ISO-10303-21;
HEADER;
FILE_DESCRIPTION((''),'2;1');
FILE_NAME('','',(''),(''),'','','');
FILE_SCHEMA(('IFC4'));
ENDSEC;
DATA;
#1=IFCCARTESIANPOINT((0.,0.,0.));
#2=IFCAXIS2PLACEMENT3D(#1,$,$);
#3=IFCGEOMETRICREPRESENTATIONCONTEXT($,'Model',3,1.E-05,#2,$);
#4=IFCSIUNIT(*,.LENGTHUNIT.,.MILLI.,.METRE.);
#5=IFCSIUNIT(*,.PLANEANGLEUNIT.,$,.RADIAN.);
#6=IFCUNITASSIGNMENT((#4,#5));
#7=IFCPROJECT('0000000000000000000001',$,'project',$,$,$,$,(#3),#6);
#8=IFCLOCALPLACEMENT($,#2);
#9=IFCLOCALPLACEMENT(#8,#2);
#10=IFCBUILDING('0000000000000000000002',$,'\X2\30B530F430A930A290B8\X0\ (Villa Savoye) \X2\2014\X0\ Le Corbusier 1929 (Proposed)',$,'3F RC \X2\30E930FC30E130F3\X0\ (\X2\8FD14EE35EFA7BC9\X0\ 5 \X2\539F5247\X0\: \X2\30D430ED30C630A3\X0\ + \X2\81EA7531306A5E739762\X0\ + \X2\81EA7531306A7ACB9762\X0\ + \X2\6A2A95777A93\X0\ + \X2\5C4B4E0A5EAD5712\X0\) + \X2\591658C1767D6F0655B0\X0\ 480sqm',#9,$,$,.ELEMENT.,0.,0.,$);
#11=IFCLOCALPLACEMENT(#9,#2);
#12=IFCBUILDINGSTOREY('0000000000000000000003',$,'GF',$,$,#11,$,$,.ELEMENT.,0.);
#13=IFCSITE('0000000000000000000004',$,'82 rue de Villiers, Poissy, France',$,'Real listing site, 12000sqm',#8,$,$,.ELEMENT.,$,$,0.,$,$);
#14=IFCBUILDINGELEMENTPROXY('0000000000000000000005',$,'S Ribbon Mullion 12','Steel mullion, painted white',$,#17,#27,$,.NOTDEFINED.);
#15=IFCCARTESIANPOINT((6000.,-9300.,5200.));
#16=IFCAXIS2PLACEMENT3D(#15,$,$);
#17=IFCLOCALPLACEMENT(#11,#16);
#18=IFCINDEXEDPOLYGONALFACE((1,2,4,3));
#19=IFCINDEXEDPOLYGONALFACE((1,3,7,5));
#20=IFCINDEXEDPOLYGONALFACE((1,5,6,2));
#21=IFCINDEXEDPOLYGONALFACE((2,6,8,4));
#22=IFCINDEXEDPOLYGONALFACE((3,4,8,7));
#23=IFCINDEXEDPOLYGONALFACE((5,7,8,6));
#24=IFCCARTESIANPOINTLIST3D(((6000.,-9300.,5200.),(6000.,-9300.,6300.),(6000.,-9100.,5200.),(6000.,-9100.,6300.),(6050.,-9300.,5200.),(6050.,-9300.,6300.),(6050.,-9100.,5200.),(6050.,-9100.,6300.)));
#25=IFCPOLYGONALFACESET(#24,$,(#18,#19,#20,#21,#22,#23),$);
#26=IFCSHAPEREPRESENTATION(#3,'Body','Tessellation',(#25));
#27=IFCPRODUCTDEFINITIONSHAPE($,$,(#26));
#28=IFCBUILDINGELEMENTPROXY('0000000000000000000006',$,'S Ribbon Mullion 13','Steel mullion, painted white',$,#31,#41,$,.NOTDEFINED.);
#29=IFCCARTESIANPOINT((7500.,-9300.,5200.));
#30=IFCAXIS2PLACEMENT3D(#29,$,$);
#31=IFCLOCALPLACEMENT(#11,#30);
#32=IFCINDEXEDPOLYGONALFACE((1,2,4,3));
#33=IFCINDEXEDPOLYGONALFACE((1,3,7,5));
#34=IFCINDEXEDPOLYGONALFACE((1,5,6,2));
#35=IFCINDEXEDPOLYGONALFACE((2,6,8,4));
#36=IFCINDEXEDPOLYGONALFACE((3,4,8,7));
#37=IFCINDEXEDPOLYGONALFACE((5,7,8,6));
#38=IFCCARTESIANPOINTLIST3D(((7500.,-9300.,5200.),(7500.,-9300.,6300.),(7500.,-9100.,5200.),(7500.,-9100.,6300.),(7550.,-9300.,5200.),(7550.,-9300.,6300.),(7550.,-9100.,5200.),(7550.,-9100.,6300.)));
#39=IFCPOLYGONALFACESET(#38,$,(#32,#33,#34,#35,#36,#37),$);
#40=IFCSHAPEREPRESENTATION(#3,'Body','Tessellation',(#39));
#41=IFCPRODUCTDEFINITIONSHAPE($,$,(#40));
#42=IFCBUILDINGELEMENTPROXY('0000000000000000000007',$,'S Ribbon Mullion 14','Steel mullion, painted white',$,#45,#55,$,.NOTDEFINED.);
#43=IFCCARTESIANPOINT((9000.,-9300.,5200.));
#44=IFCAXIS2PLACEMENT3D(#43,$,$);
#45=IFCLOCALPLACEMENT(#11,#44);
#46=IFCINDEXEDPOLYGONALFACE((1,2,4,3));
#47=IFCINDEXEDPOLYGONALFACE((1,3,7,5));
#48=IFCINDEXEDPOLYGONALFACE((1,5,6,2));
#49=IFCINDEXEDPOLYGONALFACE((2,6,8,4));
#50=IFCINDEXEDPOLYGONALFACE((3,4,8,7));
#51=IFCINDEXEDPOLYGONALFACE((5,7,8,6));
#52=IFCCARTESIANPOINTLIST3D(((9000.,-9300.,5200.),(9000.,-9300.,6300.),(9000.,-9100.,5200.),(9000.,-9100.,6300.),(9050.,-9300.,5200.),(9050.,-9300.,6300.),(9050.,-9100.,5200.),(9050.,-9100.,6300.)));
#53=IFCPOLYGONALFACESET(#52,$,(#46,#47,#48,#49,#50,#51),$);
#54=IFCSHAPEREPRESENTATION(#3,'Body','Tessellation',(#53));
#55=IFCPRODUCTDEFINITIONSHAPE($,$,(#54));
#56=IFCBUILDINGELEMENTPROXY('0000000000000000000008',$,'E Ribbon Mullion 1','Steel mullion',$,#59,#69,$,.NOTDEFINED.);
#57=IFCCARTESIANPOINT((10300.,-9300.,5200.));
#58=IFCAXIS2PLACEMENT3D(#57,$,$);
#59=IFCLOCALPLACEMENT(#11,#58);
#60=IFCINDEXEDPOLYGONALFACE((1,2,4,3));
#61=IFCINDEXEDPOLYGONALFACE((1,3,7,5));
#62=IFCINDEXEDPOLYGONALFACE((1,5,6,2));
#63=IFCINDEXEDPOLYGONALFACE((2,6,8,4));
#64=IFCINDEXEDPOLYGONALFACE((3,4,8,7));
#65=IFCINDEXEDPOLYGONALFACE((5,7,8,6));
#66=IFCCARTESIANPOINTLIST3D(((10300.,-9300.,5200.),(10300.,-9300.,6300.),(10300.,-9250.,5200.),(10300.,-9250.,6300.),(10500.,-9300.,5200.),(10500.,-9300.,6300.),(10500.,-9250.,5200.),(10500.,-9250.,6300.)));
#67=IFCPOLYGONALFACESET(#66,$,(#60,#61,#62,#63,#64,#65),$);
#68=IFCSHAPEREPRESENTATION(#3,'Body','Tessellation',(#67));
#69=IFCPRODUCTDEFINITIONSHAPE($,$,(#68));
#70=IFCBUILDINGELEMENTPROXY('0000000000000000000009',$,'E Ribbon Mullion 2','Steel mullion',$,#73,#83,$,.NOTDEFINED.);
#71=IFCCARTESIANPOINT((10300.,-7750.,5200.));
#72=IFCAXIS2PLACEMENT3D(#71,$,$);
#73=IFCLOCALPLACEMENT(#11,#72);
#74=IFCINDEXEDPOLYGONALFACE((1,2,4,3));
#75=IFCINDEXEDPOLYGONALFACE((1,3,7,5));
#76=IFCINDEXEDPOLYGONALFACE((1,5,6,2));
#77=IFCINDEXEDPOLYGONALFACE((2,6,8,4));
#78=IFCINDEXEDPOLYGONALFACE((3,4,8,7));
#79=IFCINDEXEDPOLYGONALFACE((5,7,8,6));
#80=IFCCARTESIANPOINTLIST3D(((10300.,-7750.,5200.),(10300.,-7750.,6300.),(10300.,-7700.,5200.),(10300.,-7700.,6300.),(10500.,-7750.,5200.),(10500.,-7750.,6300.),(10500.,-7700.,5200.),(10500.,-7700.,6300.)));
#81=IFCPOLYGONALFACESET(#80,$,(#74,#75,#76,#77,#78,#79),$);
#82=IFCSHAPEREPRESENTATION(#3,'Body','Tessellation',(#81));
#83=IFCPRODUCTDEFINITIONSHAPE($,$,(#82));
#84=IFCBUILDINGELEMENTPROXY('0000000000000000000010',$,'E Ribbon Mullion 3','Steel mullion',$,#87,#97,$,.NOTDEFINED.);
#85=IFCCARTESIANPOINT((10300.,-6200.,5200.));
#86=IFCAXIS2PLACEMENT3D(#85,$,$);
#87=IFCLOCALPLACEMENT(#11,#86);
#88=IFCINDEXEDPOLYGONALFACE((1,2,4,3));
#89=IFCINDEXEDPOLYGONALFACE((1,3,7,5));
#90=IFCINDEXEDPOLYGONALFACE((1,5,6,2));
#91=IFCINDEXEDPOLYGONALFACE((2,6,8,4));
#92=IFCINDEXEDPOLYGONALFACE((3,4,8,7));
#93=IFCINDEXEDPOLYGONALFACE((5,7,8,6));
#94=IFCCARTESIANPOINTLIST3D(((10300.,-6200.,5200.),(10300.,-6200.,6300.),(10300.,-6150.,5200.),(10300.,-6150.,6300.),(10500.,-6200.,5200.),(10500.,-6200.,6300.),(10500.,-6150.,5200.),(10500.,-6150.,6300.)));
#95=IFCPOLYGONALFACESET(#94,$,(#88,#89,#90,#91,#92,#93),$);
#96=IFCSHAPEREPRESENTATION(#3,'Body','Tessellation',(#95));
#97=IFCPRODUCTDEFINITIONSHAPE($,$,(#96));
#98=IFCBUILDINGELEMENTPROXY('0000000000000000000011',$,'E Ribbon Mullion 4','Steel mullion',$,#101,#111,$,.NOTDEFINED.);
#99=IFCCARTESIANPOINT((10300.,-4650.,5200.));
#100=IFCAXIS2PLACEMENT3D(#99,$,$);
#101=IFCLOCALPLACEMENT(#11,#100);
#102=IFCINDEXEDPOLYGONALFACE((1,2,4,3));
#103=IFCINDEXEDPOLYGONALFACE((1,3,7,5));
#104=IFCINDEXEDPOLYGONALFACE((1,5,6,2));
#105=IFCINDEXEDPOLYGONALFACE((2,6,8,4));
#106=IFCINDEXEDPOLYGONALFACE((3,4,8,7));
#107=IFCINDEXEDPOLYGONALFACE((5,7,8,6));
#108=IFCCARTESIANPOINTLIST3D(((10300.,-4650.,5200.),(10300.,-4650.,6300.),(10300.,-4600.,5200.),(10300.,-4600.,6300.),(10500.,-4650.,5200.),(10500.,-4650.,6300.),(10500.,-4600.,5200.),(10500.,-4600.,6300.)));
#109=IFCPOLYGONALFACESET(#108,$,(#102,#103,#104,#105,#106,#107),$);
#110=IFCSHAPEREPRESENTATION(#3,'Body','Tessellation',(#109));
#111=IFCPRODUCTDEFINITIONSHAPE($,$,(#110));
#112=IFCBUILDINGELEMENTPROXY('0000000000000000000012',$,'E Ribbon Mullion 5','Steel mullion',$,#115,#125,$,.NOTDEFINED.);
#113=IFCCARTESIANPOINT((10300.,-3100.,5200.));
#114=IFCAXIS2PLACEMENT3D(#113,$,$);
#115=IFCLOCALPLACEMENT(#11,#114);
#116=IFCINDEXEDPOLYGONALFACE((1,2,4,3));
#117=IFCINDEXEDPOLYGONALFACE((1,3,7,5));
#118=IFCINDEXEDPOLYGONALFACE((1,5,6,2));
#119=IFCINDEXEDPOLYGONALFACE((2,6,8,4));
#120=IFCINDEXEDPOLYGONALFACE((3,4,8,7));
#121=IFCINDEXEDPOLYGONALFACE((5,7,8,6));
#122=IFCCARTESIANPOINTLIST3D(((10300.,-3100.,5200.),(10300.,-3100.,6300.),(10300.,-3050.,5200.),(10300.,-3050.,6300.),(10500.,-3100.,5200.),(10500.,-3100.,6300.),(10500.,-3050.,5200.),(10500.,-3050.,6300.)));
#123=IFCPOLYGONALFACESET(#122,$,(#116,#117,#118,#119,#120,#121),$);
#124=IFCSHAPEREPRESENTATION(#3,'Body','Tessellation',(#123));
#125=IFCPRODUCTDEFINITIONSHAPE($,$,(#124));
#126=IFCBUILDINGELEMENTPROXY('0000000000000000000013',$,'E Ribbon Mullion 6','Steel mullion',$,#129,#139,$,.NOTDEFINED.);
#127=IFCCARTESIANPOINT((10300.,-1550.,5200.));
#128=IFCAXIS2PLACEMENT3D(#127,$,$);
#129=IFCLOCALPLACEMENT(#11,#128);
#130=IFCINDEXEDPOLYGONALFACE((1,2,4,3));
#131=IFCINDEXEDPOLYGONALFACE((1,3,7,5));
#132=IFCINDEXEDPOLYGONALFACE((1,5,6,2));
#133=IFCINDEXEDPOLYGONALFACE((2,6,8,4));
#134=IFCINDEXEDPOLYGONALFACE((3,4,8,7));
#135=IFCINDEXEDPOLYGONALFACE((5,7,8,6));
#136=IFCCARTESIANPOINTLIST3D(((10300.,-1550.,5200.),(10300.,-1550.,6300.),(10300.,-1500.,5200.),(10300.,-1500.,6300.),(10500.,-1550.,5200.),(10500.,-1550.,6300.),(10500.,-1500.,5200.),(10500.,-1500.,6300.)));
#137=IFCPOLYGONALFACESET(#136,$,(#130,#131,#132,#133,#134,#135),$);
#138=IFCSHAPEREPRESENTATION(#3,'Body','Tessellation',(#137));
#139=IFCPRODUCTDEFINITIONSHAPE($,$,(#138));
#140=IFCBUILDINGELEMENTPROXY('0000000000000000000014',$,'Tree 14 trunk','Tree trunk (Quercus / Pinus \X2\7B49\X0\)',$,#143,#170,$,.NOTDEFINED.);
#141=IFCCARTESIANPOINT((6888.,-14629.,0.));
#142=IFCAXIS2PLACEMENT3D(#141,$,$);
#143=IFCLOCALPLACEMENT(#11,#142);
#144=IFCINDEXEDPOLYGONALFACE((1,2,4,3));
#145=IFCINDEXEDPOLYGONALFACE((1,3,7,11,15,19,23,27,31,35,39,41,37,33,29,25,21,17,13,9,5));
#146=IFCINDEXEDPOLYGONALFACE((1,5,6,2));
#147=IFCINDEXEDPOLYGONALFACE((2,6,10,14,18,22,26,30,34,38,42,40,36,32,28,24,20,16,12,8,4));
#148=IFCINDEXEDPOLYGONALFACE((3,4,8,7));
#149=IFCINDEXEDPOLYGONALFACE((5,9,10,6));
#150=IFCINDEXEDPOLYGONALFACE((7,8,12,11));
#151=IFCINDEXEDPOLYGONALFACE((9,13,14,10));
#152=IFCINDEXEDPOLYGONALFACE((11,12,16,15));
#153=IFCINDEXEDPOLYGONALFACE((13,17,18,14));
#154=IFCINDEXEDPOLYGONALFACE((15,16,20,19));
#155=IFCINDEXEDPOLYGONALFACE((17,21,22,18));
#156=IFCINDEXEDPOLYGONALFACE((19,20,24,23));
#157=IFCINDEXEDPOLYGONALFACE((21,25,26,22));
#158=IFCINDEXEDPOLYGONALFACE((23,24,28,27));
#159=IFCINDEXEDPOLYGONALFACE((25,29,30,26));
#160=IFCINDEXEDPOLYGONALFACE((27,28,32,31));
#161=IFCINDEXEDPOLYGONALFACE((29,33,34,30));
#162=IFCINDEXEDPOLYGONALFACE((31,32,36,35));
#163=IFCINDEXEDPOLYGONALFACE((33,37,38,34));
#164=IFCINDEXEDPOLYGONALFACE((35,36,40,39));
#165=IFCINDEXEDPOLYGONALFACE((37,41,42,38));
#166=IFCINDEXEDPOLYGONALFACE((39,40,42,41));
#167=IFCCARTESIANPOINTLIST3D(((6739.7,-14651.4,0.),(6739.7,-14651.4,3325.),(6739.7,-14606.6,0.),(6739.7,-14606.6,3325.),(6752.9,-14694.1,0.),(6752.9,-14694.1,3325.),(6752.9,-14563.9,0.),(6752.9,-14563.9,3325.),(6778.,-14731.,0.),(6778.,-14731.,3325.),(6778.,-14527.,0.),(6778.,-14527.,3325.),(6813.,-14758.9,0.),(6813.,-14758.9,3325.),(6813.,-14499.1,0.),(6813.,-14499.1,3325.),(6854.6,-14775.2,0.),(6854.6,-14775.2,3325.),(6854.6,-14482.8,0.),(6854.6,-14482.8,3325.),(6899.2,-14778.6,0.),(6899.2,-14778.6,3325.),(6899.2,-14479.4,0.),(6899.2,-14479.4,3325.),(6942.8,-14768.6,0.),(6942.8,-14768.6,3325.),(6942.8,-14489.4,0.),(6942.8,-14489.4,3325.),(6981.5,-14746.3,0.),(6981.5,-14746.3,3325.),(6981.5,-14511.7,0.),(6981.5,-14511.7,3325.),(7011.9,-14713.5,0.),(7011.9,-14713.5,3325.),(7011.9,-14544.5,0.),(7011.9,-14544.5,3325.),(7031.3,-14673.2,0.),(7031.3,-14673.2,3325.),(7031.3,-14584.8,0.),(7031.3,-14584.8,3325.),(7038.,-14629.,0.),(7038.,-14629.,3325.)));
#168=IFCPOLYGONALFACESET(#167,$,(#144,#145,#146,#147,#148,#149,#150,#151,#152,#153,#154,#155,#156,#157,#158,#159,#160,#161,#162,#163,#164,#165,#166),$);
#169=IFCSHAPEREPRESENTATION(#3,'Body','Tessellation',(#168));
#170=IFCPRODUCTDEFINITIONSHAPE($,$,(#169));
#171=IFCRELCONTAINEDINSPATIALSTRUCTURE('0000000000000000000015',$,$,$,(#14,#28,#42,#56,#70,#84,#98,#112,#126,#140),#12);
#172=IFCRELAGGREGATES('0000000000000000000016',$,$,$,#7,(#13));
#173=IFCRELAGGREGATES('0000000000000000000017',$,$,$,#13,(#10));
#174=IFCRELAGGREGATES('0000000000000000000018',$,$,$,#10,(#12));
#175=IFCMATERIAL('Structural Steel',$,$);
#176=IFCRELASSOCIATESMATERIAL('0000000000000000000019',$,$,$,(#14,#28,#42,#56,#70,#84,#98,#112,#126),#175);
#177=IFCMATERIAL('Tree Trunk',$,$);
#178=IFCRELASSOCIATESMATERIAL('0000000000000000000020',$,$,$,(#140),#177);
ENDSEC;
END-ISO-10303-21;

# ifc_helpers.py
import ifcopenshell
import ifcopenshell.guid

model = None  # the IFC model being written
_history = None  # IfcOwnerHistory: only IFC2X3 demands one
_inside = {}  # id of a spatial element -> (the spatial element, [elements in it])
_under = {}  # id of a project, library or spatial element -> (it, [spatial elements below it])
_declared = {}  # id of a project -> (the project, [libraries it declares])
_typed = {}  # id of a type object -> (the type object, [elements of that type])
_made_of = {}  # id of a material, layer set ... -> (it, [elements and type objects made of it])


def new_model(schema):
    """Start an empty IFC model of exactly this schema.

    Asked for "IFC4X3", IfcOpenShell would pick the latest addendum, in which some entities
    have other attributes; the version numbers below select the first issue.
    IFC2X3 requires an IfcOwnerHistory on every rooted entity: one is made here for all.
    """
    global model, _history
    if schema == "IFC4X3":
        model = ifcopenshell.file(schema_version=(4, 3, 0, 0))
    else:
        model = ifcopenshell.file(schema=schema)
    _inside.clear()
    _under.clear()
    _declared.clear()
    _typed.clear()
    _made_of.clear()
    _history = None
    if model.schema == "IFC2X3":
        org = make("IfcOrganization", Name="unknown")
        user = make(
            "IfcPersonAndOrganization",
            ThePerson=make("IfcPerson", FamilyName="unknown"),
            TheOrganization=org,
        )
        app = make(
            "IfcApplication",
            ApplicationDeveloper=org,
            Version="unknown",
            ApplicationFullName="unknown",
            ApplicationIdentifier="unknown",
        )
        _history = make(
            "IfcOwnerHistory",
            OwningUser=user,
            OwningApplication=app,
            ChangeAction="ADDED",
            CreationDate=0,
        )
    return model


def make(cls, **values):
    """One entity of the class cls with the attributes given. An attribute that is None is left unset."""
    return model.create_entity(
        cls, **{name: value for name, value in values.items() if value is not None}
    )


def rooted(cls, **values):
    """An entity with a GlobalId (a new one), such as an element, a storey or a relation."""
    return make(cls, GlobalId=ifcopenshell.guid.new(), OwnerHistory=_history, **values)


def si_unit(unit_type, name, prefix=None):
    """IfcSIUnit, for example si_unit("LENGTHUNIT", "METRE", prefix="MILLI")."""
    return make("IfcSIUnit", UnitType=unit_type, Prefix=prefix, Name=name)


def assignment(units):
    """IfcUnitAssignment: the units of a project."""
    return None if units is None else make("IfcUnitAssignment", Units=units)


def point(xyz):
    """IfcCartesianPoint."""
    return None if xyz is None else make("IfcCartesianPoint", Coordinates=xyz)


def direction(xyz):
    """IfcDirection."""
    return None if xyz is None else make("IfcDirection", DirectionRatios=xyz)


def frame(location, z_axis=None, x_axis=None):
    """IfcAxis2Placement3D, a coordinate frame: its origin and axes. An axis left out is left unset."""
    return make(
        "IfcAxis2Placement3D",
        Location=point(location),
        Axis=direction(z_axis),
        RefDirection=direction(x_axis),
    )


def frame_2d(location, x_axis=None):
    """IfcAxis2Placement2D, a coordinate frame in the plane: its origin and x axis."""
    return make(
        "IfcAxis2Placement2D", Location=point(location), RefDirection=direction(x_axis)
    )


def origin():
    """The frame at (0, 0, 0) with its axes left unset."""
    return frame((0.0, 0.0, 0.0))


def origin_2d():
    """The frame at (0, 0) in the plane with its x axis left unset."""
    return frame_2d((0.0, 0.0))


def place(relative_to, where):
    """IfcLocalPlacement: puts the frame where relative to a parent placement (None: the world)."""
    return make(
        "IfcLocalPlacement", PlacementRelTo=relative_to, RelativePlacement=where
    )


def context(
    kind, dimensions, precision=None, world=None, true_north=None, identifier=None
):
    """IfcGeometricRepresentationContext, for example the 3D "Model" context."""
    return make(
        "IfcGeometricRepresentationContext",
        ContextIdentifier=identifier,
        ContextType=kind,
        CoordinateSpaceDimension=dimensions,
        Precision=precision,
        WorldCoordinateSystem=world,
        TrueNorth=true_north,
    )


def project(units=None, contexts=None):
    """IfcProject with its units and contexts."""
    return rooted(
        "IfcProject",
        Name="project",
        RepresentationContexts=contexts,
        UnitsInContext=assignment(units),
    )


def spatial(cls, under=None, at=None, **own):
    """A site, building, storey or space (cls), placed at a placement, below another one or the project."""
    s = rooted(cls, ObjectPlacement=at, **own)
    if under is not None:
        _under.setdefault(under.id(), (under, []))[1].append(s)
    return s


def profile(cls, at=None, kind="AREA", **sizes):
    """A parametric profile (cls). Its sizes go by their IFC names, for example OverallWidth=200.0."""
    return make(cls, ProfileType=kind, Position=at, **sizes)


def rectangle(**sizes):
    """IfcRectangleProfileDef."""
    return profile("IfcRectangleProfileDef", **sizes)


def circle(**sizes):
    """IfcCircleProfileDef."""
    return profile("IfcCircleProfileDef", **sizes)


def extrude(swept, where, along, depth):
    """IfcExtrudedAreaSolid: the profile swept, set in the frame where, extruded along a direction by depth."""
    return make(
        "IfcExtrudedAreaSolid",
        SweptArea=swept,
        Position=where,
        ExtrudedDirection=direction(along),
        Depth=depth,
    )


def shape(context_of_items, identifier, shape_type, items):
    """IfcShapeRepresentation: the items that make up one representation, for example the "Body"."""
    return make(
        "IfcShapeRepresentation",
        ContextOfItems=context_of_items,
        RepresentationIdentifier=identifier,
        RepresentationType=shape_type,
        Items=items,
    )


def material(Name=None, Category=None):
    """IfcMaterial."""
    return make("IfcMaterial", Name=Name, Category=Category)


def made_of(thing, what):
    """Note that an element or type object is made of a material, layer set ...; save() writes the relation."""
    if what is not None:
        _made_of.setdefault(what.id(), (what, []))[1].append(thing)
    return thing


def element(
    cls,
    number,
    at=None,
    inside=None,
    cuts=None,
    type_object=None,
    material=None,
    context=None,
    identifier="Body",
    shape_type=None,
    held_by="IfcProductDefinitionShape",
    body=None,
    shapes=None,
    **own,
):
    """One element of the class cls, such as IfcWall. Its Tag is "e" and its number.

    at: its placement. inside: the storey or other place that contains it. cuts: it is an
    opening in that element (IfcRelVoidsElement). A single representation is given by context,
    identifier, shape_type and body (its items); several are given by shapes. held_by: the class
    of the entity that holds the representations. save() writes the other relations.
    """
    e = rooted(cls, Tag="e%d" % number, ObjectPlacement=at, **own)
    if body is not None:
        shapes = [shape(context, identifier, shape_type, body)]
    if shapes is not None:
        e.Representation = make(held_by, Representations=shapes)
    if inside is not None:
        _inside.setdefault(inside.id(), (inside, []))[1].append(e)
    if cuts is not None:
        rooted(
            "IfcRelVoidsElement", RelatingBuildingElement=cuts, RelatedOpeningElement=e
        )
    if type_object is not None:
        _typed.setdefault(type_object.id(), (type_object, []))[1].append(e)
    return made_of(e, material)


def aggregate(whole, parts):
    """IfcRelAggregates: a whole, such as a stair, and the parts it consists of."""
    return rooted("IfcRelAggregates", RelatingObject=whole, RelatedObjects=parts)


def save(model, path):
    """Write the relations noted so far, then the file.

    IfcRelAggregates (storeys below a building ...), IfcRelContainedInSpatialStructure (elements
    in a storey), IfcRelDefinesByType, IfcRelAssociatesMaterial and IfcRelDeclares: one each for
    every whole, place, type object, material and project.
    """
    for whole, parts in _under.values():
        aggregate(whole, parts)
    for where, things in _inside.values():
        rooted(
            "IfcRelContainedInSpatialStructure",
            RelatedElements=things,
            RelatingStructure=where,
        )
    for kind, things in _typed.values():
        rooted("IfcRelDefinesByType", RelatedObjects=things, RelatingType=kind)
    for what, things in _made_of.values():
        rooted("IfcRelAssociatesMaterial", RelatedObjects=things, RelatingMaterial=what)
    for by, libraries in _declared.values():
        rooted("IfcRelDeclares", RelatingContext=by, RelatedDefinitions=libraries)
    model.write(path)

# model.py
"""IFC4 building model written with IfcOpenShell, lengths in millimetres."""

from ifc_helpers import new_model, si_unit, frame, frame_2d, origin, origin_2d, place, context, project, spatial, rectangle, circle, extrude, material, element, save


model = new_model("IFC4")

# Units and contexts
model_context = context("Model", 3, precision=1e-05, world=origin())
ifc_project = project(units=[si_unit("LENGTHUNIT", "METRE", prefix="MILLI"), si_unit("PLANEANGLEUNIT", "RADIAN")], contexts=[model_context])

# Site, building, storey
site_placement = place(None, origin())
site = spatial("IfcSite", under=ifc_project, at=site_placement, Name="82 rue de Villiers, Poissy, France", ObjectType="Real listing site, 12000sqm", CompositionType="ELEMENT", RefElevation=0.0)
building_placement = place(site_placement, origin())
building = spatial("IfcBuilding", under=site, at=building_placement, Name="サヴォア邸 (Villa Savoye) — Le Corbusier 1929 (Proposed)", ObjectType="3F RC ラーメン (近代建築 5 原則: ピロティ + 自由な平面 + 自由な立面 + 横長窓 + 屋上庭園) + 外壁白漆喰 480sqm", CompositionType="ELEMENT", ElevationOfRefHeight=0.0, ElevationOfTerrain=0.0)
storey_placement = place(building_placement, origin())
storey = spatial("IfcBuildingStorey", under=building, at=storey_placement, Name="GF", CompositionType="ELEMENT", Elevation=0.0)

# Building element proxies
ifc_material_1 = material(Name="Structural Steel")
proxy_1_placement = place(storey_placement, frame((6000.0, -9300.0, 5200.0)))
element("IfcBuildingElementProxy", 1, at=proxy_1_placement, inside=storey, material=ifc_material_1, Name="S Ribbon Mullion 12", Description="Steel mullion, painted white", PredefinedType="NOTDEFINED", context=model_context, shape_type="SweptSolid", body=[
    extrude(rectangle(XDim=50.0, YDim=200.0, at=frame_2d((25.0, 100.0))), frame((6000.0, -9300.0, 5200.0)), (0.0, 0.0, 1.0), 1100.0),
])
proxy_2_placement = place(storey_placement, frame((7500.0, -9300.0, 5200.0)))
element("IfcBuildingElementProxy", 2, at=proxy_2_placement, inside=storey, material=ifc_material_1, Name="S Ribbon Mullion 13", Description="Steel mullion, painted white", PredefinedType="NOTDEFINED", context=model_context, shape_type="SweptSolid", body=[
    extrude(rectangle(XDim=50.0, YDim=200.0, at=frame_2d((25.0, 100.0))), frame((7500.0, -9300.0, 5200.0)), (0.0, 0.0, 1.0), 1100.0),
])
proxy_3_placement = place(storey_placement, frame((9000.0, -9300.0, 5200.0)))
element("IfcBuildingElementProxy", 3, at=proxy_3_placement, inside=storey, material=ifc_material_1, Name="S Ribbon Mullion 14", Description="Steel mullion, painted white", PredefinedType="NOTDEFINED", context=model_context, shape_type="SweptSolid", body=[
    extrude(rectangle(XDim=50.0, YDim=200.0, at=frame_2d((25.0, 100.0))), frame((9000.0, -9300.0, 5200.0)), (0.0, 0.0, 1.0), 1100.0),
])
proxy_4_placement = place(storey_placement, frame((10300.0, -9300.0, 5200.0)))
element("IfcBuildingElementProxy", 4, at=proxy_4_placement, inside=storey, material=ifc_material_1, Name="E Ribbon Mullion 1", Description="Steel mullion", PredefinedType="NOTDEFINED", context=model_context, shape_type="SweptSolid", body=[
    extrude(rectangle(XDim=200.0, YDim=50.0, at=frame_2d((100.0, 25.0))), frame((10300.0, -9300.0, 5200.0)), (0.0, 0.0, 1.0), 1100.0),
])
proxy_5_placement = place(storey_placement, frame((10300.0, -7750.0, 5200.0)))
element("IfcBuildingElementProxy", 5, at=proxy_5_placement, inside=storey, material=ifc_material_1, Name="E Ribbon Mullion 2", Description="Steel mullion", PredefinedType="NOTDEFINED", context=model_context, shape_type="SweptSolid", body=[
    extrude(rectangle(XDim=200.0, YDim=50.0, at=frame_2d((100.0, 25.0))), frame((10300.0, -7750.0, 5200.0)), (0.0, 0.0, 1.0), 1100.0),
])
proxy_6_placement = place(storey_placement, frame((10300.0, -6200.0, 5200.0)))
element("IfcBuildingElementProxy", 6, at=proxy_6_placement, inside=storey, material=ifc_material_1, Name="E Ribbon Mullion 3", Description="Steel mullion", PredefinedType="NOTDEFINED", context=model_context, shape_type="SweptSolid", body=[
    extrude(rectangle(XDim=200.0, YDim=50.0, at=frame_2d((100.0, 25.0))), frame((10300.0, -6200.0, 5200.0)), (0.0, 0.0, 1.0), 1100.0),
])
proxy_7_placement = place(storey_placement, frame((10300.0, -4650.0, 5200.0)))
element("IfcBuildingElementProxy", 7, at=proxy_7_placement, inside=storey, material=ifc_material_1, Name="E Ribbon Mullion 4", Description="Steel mullion", PredefinedType="NOTDEFINED", context=model_context, shape_type="SweptSolid", body=[
    extrude(rectangle(XDim=200.0, YDim=50.0, at=frame_2d((100.0, 25.0))), frame((10300.0, -4650.0, 5200.0)), (0.0, 0.0, 1.0), 1100.0),
])
proxy_8_placement = place(storey_placement, frame((10300.0, -3100.0, 5200.0)))
element("IfcBuildingElementProxy", 8, at=proxy_8_placement, inside=storey, material=ifc_material_1, Name="E Ribbon Mullion 5", Description="Steel mullion", PredefinedType="NOTDEFINED", context=model_context, shape_type="SweptSolid", body=[
    extrude(rectangle(XDim=200.0, YDim=50.0, at=frame_2d((100.0, 25.0))), frame((10300.0, -3100.0, 5200.0)), (0.0, 0.0, 1.0), 1100.0),
])
proxy_9_placement = place(storey_placement, frame((10300.0, -1550.0, 5200.0)))
element("IfcBuildingElementProxy", 9, at=proxy_9_placement, inside=storey, material=ifc_material_1, Name="E Ribbon Mullion 6", Description="Steel mullion", PredefinedType="NOTDEFINED", context=model_context, shape_type="SweptSolid", body=[
    extrude(rectangle(XDim=200.0, YDim=50.0, at=frame_2d((100.0, 25.0))), frame((10300.0, -1550.0, 5200.0)), (0.0, 0.0, 1.0), 1100.0),
])
ifc_material_2 = material(Name="Tree Trunk")
proxy_10_placement = place(storey_placement, frame((6888.0, -14629.0, 0.0)))
element("IfcBuildingElementProxy", 10, at=proxy_10_placement, inside=storey, material=ifc_material_2, Name="Tree 14 trunk", Description="Tree trunk (Quercus / Pinus 等)", PredefinedType="NOTDEFINED", context=model_context, shape_type="SweptSolid", body=[
    extrude(circle(Radius=150.0, at=origin_2d()), frame((6888.0, -14629.0, 0.0)), (0.0, 0.0, 1.0), 3325.0),
])

save(model, "model.ifc")
